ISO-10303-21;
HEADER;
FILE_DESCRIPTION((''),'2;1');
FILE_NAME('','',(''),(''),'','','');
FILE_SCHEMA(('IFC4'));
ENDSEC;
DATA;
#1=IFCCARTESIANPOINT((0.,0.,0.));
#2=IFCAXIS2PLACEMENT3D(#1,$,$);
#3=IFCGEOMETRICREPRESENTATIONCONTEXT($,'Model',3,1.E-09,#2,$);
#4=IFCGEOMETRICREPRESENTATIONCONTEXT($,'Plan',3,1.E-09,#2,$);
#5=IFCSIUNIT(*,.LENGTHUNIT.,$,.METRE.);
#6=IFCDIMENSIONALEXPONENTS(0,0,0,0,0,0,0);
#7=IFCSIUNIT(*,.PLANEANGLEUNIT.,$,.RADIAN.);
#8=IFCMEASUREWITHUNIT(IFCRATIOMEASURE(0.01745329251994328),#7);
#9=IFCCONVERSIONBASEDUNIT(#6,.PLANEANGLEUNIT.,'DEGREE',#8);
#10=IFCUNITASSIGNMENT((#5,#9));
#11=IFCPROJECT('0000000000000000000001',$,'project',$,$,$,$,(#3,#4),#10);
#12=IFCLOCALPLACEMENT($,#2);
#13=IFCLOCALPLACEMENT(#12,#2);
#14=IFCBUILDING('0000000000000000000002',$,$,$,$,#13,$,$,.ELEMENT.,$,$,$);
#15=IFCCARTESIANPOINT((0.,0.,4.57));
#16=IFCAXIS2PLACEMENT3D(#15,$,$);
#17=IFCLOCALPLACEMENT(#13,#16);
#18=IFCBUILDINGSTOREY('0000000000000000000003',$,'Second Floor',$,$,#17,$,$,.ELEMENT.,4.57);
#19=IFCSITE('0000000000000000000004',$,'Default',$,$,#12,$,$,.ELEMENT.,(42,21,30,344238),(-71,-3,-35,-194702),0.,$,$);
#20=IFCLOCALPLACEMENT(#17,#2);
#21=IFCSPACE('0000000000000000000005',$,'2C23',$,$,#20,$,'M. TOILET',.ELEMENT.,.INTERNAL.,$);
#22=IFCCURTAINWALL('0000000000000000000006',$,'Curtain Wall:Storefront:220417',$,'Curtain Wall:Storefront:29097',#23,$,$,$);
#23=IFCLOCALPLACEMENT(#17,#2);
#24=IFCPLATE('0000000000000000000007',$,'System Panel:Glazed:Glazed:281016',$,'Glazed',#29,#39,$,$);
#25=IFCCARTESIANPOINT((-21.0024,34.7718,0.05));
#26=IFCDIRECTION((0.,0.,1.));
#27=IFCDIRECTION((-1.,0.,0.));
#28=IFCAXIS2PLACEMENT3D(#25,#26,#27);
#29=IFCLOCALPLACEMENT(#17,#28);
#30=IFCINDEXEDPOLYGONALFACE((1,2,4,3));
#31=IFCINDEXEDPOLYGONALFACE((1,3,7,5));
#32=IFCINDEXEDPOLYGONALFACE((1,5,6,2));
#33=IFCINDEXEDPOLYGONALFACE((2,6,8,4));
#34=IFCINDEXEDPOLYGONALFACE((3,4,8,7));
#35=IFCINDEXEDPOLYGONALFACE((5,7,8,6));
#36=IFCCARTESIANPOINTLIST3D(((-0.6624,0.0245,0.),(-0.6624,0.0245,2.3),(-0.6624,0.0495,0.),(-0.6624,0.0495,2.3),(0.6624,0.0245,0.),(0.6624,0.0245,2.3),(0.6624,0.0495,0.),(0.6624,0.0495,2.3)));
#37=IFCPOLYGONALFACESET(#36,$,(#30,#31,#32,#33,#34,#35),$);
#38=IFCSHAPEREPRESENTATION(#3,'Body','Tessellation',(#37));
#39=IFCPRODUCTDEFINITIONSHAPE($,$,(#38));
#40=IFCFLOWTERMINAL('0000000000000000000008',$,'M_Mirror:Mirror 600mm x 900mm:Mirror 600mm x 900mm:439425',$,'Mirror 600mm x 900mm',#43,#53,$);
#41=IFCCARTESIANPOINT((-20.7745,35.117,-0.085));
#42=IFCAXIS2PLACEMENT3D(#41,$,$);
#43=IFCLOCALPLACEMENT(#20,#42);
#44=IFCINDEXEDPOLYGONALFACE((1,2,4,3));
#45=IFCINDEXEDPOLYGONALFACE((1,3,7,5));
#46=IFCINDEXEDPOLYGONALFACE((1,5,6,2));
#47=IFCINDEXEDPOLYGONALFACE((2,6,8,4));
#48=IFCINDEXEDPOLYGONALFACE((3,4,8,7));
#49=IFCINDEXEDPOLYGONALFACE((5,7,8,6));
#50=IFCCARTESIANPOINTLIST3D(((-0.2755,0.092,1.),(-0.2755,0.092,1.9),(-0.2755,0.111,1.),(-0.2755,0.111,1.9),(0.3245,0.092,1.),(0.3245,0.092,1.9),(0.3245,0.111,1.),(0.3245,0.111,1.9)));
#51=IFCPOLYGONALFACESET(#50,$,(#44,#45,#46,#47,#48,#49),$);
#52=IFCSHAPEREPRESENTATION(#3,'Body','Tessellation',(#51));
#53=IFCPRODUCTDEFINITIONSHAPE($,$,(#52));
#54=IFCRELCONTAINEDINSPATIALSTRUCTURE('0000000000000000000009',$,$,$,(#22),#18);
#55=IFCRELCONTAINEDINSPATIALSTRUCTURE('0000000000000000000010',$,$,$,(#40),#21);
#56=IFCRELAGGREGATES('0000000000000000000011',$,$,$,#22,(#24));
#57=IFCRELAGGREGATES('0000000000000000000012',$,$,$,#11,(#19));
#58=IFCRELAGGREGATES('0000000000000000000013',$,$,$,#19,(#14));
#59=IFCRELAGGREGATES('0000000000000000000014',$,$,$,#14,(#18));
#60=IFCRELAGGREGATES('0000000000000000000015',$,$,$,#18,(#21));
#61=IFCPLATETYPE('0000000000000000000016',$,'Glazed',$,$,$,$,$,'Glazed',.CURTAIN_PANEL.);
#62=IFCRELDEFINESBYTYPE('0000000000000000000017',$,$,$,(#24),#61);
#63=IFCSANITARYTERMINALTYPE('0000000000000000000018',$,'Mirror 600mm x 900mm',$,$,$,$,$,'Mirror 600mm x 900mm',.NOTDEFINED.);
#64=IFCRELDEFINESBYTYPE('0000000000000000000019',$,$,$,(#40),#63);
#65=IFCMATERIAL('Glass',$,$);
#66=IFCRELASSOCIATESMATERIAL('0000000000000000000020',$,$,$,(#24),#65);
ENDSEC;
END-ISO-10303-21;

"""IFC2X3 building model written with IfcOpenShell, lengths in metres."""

from ifc_helpers import new_model, entity, si_unit, converted_unit, frame, origin, origin_2d_with_axis, place, context, project, spatial, rectangle, extrude, source, transform, mapped, material, type_object, type_shapes, element, aggregate, save


model = new_model("IFC2X3")

# Units and contexts
model_context = context("Model", 3, precision=1e-09, world=origin())
plan_context = context("Plan", 3, precision=1e-09, world=origin())
ifc_project = project(units=[si_unit("LENGTHUNIT", "METRE"), converted_unit("PLANEANGLEUNIT", "DEGREE", entity("IfcRatioMeasure", 0.01745329251994328), si_unit("PLANEANGLEUNIT", "RADIAN"), dimensions=[0, 0, 0, 0, 0, 0, 0])], contexts=[model_context, plan_context])

# Site, building, storey
site_placement = place(None, origin())
site = spatial("IfcSite", under=ifc_project, at=site_placement, Name="Default", CompositionType="ELEMENT", RefLatitude=(42, 21, 30, 344238), RefLongitude=(-71, -3, -35, -194702), RefElevation=0.0)
building_placement = place(site_placement, origin())
building = spatial("IfcBuilding", under=site, at=building_placement, CompositionType="ELEMENT")
storey_placement = place(building_placement, frame((0.0, 0.0, 4.57)))
storey = spatial("IfcBuildingStorey", under=building, at=storey_placement, Name="Second Floor", CompositionType="ELEMENT", Elevation=4.57)

# Curtain wall, plate
curtain_wall_placement = place(storey_placement, origin())
curtain_wall = element("IfcCurtainWall", 1, at=curtain_wall_placement, inside=storey, Name="Curtain Wall:Storefront:220417", ObjectType="Curtain Wall:Storefront:29097")
ifc_material_1 = material(Name="Glass")
plate_type = type_object("IfcPlateType", Name="Glazed", ElementType="Glazed", PredefinedType="CURTAIN_PANEL")
shared_shape_1 = source(origin(), model_context, "Body", "SweptSolid", [
    extrude(rectangle(XDim=0.025, YDim=1.3249, at=origin_2d_with_axis()), frame((0.0, 0.037, 0.0), z_axis=(0.0, 0.0, 1.0), x_axis=(0.0, 1.0, 0.0)), (0.0, 0.0, 1.0), 2.3),
])
type_shapes(plate_type, [shared_shape_1])
plate_placement = place(storey_placement, frame((-21.0024, 34.7718, 0.05), z_axis=(0.0, 0.0, 1.0), x_axis=(-1.0, 0.0, 0.0)))
plate = element("IfcPlate", 2, at=plate_placement, type_object=plate_type, material=ifc_material_1, Name="System Panel:Glazed:Glazed:281016", ObjectType="Glazed", context=model_context, shape_type="MappedRepresentation", body=[
    mapped(shared_shape_1, transform((0.0, 0.0, 0.0), scale=1.0)),
])
aggregate(curtain_wall, [plate])

# Shared definitions
space_placement = place(storey_placement, origin())
space = spatial("IfcSpace", under=storey, at=space_placement, Name="2C23", LongName="M. TOILET", CompositionType="ELEMENT", InteriorOrExteriorSpace="INTERNAL")

# Flow terminal
sanitary_terminal_type = type_object("IfcSanitaryTerminalType", Name="Mirror 600mm x 900mm", ElementType="Mirror 600mm x 900mm", PredefinedType="NOTDEFINED")
shared_shape_2 = source(origin(), model_context, "Body", "SweptSolid", [
    extrude(rectangle(XDim=0.0191, YDim=0.6, at=origin_2d_with_axis()), frame((0.0245, 0.1015, 1.0), z_axis=(0.0, 0.0, 1.0), x_axis=(0.0, -1.0, 0.0)), (0.0, 0.0, 1.0), 0.9),
])
type_shapes(sanitary_terminal_type, [shared_shape_2])
flow_terminal_placement = place(space_placement, frame((-20.7745, 35.117, -0.085)))
element("IfcFlowTerminal", 3, at=flow_terminal_placement, inside=space, type_object=sanitary_terminal_type, Name="M_Mirror:Mirror 600mm x 900mm:Mirror 600mm x 900mm:439425", ObjectType="Mirror 600mm x 900mm", context=model_context, shape_type="MappedRepresentation", body=[
    mapped(shared_shape_2, transform((0.0, 0.0, 0.0), scale=1.0)),
])

save(model, "model.ifc")
